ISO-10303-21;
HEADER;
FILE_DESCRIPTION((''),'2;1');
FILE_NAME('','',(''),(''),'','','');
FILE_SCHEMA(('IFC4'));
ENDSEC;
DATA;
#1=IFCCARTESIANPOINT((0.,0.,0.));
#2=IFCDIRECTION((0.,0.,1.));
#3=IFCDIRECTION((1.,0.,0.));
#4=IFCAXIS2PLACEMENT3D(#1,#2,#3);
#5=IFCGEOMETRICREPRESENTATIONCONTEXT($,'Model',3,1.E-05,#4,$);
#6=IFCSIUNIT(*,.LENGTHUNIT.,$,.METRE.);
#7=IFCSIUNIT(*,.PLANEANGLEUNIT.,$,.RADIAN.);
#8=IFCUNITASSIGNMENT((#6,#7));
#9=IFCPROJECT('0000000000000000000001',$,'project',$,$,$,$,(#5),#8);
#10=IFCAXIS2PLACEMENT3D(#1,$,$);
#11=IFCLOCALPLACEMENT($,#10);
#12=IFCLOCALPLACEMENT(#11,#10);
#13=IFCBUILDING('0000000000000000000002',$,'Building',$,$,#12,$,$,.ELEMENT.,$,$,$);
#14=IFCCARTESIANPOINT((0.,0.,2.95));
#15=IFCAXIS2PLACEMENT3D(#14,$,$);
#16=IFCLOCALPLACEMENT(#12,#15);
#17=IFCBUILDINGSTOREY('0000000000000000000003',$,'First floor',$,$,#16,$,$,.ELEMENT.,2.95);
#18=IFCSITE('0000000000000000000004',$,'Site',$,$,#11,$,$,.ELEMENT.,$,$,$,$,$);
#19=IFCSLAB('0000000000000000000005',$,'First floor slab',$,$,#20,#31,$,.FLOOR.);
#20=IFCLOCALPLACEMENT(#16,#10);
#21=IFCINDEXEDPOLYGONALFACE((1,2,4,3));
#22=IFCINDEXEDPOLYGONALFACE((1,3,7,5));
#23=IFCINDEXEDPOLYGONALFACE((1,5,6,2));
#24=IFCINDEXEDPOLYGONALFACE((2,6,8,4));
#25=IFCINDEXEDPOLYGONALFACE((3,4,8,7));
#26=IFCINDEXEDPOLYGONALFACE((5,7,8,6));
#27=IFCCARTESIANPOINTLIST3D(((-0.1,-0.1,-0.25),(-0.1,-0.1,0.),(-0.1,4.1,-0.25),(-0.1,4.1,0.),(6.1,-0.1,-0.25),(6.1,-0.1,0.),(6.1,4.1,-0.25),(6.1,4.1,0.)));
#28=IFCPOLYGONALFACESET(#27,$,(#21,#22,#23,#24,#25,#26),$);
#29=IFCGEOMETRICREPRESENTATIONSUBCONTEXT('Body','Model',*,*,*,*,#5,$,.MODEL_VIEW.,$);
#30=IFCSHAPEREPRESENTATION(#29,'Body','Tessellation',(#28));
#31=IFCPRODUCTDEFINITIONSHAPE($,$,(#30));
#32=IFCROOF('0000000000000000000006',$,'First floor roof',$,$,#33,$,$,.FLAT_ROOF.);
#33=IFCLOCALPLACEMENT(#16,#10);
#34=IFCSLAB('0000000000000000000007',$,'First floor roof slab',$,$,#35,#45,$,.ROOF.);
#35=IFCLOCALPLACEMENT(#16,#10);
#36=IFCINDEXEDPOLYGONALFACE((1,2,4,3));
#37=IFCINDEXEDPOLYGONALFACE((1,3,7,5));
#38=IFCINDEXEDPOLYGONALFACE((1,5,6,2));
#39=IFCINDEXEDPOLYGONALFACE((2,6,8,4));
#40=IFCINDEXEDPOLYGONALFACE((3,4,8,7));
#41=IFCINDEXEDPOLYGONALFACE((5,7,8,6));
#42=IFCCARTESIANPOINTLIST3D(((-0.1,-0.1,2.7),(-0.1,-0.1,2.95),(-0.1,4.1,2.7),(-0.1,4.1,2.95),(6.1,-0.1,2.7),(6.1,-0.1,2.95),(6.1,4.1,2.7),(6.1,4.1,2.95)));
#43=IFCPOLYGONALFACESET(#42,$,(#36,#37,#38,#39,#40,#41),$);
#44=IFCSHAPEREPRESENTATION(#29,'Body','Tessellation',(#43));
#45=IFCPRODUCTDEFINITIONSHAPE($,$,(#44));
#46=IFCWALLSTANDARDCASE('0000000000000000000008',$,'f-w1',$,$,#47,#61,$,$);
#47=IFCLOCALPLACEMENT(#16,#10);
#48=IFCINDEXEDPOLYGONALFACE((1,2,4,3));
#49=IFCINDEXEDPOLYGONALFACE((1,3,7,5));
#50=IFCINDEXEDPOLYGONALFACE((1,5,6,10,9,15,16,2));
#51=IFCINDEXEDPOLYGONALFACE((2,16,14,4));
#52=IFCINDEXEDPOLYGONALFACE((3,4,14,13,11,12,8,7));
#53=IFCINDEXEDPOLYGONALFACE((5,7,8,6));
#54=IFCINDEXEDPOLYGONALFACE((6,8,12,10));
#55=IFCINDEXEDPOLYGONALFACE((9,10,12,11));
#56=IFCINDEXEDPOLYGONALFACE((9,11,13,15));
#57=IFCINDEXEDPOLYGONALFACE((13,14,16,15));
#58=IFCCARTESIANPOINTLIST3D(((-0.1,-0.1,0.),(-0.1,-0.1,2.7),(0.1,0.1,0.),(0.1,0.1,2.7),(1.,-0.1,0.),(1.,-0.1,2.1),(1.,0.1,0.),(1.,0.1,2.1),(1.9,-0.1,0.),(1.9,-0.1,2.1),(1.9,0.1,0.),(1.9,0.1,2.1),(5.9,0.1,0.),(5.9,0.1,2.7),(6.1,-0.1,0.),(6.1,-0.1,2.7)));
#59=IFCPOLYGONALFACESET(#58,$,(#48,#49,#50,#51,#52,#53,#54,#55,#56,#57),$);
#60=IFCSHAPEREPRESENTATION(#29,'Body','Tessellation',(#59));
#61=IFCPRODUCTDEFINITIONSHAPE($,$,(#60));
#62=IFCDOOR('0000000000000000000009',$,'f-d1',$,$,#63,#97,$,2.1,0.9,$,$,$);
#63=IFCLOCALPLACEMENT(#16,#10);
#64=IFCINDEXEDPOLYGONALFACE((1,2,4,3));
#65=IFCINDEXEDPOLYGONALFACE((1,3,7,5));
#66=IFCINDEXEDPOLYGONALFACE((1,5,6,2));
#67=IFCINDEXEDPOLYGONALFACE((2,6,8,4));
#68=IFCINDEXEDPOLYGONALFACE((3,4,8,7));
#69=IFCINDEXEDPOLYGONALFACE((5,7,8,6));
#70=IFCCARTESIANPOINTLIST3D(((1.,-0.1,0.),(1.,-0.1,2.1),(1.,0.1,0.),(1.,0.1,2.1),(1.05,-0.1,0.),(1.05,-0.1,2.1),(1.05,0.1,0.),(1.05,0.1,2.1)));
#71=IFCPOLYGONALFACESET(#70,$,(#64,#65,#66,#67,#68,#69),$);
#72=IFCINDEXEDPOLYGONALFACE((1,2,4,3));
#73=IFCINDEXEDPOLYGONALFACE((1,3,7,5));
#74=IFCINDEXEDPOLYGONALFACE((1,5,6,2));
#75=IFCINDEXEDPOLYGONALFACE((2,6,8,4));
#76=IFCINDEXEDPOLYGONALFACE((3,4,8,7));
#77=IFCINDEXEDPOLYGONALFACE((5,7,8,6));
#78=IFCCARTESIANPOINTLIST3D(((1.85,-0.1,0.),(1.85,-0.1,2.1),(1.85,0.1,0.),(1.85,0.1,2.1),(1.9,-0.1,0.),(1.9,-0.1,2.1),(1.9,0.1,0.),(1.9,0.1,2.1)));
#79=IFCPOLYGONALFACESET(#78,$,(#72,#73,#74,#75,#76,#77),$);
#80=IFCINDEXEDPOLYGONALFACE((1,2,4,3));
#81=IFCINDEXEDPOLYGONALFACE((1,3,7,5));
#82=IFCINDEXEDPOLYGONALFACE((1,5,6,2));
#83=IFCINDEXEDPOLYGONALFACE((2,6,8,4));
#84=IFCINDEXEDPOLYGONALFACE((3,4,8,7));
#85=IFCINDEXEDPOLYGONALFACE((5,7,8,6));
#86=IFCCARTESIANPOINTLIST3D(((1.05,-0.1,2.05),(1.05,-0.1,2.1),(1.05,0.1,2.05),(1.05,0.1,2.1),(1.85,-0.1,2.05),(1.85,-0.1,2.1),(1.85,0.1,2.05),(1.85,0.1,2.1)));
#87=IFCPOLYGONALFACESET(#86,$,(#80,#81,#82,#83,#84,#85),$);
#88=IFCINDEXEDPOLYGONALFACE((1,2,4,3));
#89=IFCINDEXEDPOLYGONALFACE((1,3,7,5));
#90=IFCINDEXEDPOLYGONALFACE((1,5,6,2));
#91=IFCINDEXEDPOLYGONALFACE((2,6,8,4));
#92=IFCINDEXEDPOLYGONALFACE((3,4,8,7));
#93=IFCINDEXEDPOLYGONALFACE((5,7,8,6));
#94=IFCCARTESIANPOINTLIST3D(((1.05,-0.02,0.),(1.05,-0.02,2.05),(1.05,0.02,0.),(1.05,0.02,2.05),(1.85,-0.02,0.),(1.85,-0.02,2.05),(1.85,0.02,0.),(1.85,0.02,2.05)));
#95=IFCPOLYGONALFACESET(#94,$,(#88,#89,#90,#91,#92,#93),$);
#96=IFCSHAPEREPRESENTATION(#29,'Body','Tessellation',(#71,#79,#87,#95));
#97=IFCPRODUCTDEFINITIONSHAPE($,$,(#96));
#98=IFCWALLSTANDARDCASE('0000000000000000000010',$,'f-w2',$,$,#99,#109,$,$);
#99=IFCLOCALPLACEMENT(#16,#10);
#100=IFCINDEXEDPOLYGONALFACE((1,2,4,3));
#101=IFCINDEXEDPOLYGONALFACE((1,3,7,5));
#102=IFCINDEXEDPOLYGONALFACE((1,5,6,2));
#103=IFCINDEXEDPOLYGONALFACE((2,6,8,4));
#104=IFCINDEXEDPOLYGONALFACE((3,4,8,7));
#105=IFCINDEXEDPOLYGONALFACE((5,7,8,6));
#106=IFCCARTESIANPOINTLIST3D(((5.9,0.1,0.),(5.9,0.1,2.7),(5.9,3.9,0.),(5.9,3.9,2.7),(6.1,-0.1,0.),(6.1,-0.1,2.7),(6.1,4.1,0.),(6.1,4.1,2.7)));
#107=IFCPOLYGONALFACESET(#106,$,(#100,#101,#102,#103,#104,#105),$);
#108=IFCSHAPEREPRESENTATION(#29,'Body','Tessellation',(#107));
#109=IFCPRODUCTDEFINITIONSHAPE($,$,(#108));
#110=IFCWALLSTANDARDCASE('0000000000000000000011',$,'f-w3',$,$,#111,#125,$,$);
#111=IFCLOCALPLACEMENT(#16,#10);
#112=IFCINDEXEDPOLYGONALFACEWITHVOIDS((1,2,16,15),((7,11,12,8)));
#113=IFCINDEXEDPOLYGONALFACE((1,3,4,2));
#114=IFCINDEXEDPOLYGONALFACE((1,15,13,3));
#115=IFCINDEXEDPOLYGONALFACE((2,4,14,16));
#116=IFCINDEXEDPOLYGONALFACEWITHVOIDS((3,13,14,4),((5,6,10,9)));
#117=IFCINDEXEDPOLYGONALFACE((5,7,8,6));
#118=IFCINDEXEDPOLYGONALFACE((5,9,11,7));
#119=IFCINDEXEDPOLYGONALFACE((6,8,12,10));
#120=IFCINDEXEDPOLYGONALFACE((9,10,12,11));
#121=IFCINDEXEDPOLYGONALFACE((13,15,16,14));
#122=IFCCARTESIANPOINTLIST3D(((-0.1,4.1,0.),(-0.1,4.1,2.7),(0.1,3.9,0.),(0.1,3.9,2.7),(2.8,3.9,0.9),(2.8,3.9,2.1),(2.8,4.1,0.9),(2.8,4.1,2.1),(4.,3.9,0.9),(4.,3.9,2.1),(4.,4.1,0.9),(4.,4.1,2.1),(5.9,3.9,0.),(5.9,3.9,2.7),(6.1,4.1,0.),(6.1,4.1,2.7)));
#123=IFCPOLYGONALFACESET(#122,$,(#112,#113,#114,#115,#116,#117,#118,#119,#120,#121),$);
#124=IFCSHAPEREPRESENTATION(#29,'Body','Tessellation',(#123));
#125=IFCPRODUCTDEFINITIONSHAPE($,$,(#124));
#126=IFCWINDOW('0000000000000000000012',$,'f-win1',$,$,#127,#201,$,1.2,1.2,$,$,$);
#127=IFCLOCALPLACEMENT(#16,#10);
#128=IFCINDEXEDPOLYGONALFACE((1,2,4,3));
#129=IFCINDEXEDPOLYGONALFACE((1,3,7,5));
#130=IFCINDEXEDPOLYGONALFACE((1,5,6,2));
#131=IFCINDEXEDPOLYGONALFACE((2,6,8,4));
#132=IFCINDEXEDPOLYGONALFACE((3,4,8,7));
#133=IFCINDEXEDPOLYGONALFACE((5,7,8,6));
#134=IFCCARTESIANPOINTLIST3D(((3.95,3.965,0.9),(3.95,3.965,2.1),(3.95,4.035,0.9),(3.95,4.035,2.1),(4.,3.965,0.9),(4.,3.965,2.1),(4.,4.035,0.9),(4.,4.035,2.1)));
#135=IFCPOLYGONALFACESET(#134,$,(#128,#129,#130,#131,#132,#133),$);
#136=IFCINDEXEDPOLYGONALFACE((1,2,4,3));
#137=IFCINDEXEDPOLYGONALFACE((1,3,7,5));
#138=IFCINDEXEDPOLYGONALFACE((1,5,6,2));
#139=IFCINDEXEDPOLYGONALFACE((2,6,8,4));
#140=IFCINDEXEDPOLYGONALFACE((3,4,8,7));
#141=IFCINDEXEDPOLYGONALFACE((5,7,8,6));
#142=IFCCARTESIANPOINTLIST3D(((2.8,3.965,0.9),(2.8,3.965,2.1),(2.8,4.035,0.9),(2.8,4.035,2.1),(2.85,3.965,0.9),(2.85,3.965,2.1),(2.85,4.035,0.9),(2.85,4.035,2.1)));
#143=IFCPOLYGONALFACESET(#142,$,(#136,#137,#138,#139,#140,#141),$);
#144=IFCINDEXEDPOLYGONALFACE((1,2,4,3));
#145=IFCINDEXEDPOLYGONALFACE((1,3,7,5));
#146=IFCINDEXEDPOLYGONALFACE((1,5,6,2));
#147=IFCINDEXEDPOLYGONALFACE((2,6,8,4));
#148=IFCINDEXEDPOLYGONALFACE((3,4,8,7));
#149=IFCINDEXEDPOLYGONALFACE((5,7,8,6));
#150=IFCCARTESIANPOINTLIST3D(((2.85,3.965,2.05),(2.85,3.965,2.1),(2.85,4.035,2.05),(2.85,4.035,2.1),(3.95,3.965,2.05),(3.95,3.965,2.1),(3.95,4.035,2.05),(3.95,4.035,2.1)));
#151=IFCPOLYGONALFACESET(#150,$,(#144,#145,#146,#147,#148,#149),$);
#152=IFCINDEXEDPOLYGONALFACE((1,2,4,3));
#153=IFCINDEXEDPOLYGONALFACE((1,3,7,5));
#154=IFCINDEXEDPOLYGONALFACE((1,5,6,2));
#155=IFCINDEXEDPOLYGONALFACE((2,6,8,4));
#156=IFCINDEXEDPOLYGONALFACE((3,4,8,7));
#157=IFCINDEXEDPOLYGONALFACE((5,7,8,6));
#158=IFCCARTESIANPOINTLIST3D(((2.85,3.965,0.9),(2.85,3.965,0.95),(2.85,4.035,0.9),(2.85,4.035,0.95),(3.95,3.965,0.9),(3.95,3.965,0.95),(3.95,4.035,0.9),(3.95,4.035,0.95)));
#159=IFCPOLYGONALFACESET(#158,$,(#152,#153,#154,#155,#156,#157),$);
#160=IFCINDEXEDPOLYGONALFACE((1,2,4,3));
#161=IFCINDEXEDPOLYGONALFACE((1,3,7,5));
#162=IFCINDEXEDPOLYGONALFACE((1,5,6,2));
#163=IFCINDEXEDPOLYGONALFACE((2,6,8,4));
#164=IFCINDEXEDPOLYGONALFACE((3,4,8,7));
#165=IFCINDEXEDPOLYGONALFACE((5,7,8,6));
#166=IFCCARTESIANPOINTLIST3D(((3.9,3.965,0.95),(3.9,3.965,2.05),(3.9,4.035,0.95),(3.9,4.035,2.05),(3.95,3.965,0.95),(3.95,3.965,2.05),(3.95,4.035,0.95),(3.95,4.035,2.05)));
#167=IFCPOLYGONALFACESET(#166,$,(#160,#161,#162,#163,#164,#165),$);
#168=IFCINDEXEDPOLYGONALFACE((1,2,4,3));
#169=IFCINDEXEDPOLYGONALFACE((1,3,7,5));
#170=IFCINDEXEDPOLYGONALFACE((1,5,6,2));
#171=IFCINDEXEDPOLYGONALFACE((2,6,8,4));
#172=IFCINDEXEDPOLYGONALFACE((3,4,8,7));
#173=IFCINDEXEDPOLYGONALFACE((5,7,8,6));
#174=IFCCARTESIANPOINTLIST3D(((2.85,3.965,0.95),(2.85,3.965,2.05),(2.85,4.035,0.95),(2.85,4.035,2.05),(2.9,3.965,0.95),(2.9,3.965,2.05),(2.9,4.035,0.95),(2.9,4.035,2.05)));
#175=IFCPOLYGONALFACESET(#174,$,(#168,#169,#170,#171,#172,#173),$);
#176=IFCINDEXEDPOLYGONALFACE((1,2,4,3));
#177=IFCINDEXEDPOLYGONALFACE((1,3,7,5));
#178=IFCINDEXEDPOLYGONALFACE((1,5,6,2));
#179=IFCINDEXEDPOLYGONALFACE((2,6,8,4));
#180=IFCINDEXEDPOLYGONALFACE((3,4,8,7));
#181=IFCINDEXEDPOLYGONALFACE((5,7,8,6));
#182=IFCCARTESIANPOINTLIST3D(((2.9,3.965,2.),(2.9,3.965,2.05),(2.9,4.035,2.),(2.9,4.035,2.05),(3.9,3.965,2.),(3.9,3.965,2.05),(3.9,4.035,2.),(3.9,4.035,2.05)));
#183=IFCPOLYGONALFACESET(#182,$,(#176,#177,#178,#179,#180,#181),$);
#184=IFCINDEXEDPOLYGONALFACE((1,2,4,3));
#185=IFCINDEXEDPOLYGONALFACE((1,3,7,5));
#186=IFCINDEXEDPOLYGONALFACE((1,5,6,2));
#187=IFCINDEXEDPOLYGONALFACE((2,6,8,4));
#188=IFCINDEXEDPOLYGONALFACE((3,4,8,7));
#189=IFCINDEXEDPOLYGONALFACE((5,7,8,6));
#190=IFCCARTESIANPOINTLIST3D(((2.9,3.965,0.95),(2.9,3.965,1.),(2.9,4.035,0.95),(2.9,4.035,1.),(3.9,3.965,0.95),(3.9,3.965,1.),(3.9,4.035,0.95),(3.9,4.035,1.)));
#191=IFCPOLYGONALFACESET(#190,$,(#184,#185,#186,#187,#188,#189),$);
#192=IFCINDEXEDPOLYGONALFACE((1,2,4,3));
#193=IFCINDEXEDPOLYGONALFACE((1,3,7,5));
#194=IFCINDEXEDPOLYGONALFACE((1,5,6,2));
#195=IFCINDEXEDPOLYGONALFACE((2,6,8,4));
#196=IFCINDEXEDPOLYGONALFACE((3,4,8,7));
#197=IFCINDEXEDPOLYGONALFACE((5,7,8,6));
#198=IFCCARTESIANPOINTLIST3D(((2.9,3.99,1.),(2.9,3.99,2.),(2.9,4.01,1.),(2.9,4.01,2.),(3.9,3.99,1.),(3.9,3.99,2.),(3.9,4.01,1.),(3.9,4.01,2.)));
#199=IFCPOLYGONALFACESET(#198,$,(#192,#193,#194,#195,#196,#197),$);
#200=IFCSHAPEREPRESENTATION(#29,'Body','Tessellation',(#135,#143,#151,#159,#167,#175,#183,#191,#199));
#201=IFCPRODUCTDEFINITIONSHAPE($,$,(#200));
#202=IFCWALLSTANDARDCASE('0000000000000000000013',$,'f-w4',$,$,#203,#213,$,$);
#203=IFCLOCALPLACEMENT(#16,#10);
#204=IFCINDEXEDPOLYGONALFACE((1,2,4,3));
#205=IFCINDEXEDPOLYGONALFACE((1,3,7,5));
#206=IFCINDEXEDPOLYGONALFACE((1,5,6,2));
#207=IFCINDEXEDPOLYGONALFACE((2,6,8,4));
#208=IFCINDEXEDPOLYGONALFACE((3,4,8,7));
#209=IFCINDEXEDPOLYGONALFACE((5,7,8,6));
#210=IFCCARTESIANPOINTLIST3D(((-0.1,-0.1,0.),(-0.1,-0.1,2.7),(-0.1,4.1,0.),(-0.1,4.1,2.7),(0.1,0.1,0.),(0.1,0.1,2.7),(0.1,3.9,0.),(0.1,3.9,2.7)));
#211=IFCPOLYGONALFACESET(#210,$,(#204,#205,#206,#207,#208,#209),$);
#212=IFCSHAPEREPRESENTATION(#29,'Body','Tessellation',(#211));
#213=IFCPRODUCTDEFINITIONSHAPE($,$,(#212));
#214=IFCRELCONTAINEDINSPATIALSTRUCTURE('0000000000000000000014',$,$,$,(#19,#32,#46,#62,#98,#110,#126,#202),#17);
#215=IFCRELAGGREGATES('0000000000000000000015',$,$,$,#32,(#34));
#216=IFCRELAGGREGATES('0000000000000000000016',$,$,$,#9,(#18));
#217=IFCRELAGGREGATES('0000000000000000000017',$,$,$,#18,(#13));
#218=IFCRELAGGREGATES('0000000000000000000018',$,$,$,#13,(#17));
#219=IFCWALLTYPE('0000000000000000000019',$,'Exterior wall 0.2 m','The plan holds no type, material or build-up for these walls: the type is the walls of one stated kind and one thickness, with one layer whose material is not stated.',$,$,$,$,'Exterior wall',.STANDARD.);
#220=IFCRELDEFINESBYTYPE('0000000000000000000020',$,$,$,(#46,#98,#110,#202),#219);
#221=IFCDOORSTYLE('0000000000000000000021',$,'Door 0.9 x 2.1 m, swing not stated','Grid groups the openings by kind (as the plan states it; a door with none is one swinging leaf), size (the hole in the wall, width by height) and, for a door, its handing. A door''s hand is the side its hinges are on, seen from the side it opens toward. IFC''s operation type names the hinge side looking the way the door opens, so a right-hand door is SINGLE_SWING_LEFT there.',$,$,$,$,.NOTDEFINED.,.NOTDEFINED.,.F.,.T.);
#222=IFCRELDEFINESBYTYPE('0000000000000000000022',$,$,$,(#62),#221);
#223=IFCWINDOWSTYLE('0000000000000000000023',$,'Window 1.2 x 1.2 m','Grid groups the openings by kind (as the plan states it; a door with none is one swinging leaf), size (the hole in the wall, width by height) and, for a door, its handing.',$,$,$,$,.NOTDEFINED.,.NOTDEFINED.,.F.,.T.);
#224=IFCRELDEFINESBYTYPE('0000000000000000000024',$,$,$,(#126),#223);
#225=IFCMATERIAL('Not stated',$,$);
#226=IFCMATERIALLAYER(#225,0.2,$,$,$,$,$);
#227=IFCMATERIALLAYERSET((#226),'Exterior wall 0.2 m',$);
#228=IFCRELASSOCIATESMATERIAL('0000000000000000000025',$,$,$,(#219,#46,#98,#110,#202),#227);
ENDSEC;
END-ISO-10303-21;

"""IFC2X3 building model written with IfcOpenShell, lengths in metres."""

from ifc_helpers import new_model, si_unit, frame, frame_2d, origin, origin_with_axes, place, context, subcontext, project, spatial, polyline, rectangle, outline, extrude, material, layer, layer_set, layer_usage, type_object, element, fill, aggregate, save


model = new_model("IFC2X3")

# Units and contexts
model_context = context("Model", 3, precision=1e-05, world=origin_with_axes())
body_context = subcontext(model_context, "Body", "Model", "MODEL_VIEW")
ifc_project = project(units=[si_unit("LENGTHUNIT", "METRE"), si_unit("PLANEANGLEUNIT", "RADIAN")], contexts=[model_context])

# Site, building, storey
site_placement = place(None, origin())
site = spatial("IfcSite", under=ifc_project, at=site_placement, Name="Site", CompositionType="ELEMENT")
building_placement = place(site_placement, origin())
building = spatial("IfcBuilding", under=site, at=building_placement, Name="Building", CompositionType="ELEMENT")
storey_placement = place(building_placement, frame((0.0, 0.0, 2.95)))
storey = spatial("IfcBuildingStorey", under=building, at=storey_placement, Name="First floor", CompositionType="ELEMENT", Elevation=2.95)

# Slab
slab_1_placement = place(storey_placement, frame((0.0, 0.0, -0.25)))
element("IfcSlab", 1, at=slab_1_placement, inside=storey, Name="First floor slab", PredefinedType="FLOOR", context=body_context, shape_type="SweptSolid", body=[
    extrude(outline(polyline([(-0.1, -0.1), (6.1, -0.1), (6.1, 4.1), (-0.1, 4.1), (-0.1, -0.1)])), origin(), (0.0, 0.0, 1.0), 0.25),
])

# Roof, slab
roof_placement = place(storey_placement, origin())
roof = element("IfcRoof", 2, at=roof_placement, inside=storey, Name="First floor roof", ShapeType="FLAT_ROOF")
slab_2_placement = place(storey_placement, frame((0.0, 0.0, 2.7)))
slab_2 = element("IfcSlab", 3, at=slab_2_placement, Name="First floor roof slab", PredefinedType="ROOF", context=body_context, shape_type="SweptSolid", body=[
    extrude(outline(polyline([(-0.1, -0.1), (6.1, -0.1), (6.1, 4.1), (-0.1, 4.1), (-0.1, -0.1)])), origin(), (0.0, 0.0, 1.0), 0.25),
])
aggregate(roof, [slab_2])

# Wall, opening, door
ifc_material = material(Name="Not stated")
ifc_layer = layer(ifc_material, 0.2)
ifc_layer_set = layer_set([ifc_layer], Name="Exterior wall 0.2 m")
ifc_layer_usage = layer_usage(ifc_layer_set, "AXIS2", "POSITIVE", -0.1)
wall_type = type_object("IfcWallType", Name="Exterior wall 0.2 m", Description="The plan holds no type, material or build-up for these walls: the type is the walls of one stated kind and one thickness, with one layer whose material is not stated.", ElementType="Exterior wall", PredefinedType="STANDARD", material=ifc_layer_set)
wall_1_placement = place(storey_placement, origin_with_axes())
wall_1 = element("IfcWallStandardCase", 4, at=wall_1_placement, inside=storey, type_object=wall_type, material=ifc_layer_usage, Name="f-w1", context=body_context, shape_type="SweptSolid", body=[
    extrude(outline(polyline([(-0.1, -0.1), (6.1, -0.1), (5.9, 0.1), (0.1, 0.1), (-0.1, -0.1)])), origin(), (0.0, 0.0, 1.0), 2.7),
])
opening_1_placement = place(wall_1_placement, frame((1.0, 0.0, 0.0)))
opening_1 = element("IfcOpeningElement", 5, at=opening_1_placement, cuts=wall_1, context=body_context, shape_type="SweptSolid", body=[
    extrude(rectangle(XDim=0.9, YDim=0.22, at=frame_2d((0.45, 0.0), x_axis=(1.0, 0.0))), origin(), (0.0, 0.0, 1.0), 2.1),
])
door_style = type_object("IfcDoorStyle", Name="Door 0.9 x 2.1 m, swing not stated", Description="Grid groups the openings by kind (as the plan states it; a door with none is one swinging leaf), size (the hole in the wall, width by height) and, for a door, its handing. A door's hand is the side its hinges are on, seen from the side it opens toward. IFC's operation type names the hinge side looking the way the door opens, so a right-hand door is SINGLE_SWING_LEFT there.", ConstructionType="NOTDEFINED", OperationType="NOTDEFINED", ParameterTakesPrecedence=False, Sizeable=True)
door_placement = place(opening_1_placement, origin())
door = element("IfcDoor", 6, at=door_placement, inside=storey, type_object=door_style, Name="f-d1", OverallHeight=2.1, OverallWidth=0.9, context=body_context, shape_type="SweptSolid", body=[
    extrude(rectangle(XDim=0.05, YDim=0.2, at=frame_2d((0.025, 0.0), x_axis=(1.0, 0.0))), origin(), (0.0, 0.0, 1.0), 2.1),
    extrude(rectangle(XDim=0.05, YDim=0.2, at=frame_2d((0.875, 0.0), x_axis=(1.0, 0.0))), origin(), (0.0, 0.0, 1.0), 2.1),
    extrude(rectangle(XDim=0.8, YDim=0.2, at=frame_2d((0.45, 0.0), x_axis=(1.0, 0.0))), frame((0.0, 0.0, 2.05)), (0.0, 0.0, 1.0), 0.05),
    extrude(rectangle(XDim=0.8, YDim=0.04, at=frame_2d((0.45, 0.0), x_axis=(1.0, 0.0))), origin(), (0.0, 0.0, 1.0), 2.05),
])
fill(opening_1, door)

# Wall
wall_2_placement = place(storey_placement, frame((6.0, 0.0, 0.0), z_axis=(0.0, 0.0, 1.0), x_axis=(0.0, 1.0, 0.0)))
element("IfcWallStandardCase", 7, at=wall_2_placement, inside=storey, type_object=wall_type, material=ifc_layer_usage, Name="f-w2", context=body_context, shape_type="SweptSolid", body=[
    extrude(outline(polyline([(-0.1, -0.1), (4.1, -0.1), (3.9, 0.1), (0.1, 0.1), (-0.1, -0.1)])), origin(), (0.0, 0.0, 1.0), 2.7),
])

# Wall, opening, window
wall_3_placement = place(storey_placement, frame((6.0, 4.0, 0.0), z_axis=(0.0, 0.0, 1.0), x_axis=(-1.0, 0.0, 0.0)))
wall_3 = element("IfcWallStandardCase", 8, at=wall_3_placement, inside=storey, type_object=wall_type, material=ifc_layer_usage, Name="f-w3", context=body_context, shape_type="SweptSolid", body=[
    extrude(outline(polyline([(-0.1, -0.1), (6.1, -0.1), (5.9, 0.1), (0.1, 0.1), (-0.1, -0.1)])), origin(), (0.0, 0.0, 1.0), 2.7),
])
opening_2_placement = place(wall_3_placement, frame((2.0, 0.0, 0.9)))
opening_2 = element("IfcOpeningElement", 9, at=opening_2_placement, cuts=wall_3, context=body_context, shape_type="SweptSolid", body=[
    extrude(rectangle(XDim=1.2, YDim=0.22, at=frame_2d((0.6, 0.0), x_axis=(1.0, 0.0))), origin(), (0.0, 0.0, 1.0), 1.2),
])
window_style = type_object("IfcWindowStyle", Name="Window 1.2 x 1.2 m", Description="Grid groups the openings by kind (as the plan states it; a door with none is one swinging leaf), size (the hole in the wall, width by height) and, for a door, its handing.", ConstructionType="NOTDEFINED", OperationType="NOTDEFINED", ParameterTakesPrecedence=False, Sizeable=True)
window_placement = place(opening_2_placement, origin())
window = element("IfcWindow", 10, at=window_placement, inside=storey, type_object=window_style, Name="f-win1", OverallHeight=1.2, OverallWidth=1.2, context=body_context, shape_type="SweptSolid", body=[
    extrude(rectangle(XDim=0.05, YDim=0.07, at=frame_2d((0.025, 0.0), x_axis=(1.0, 0.0))), origin(), (0.0, 0.0, 1.0), 1.2),
    extrude(rectangle(XDim=0.05, YDim=0.07, at=frame_2d((1.175, 0.0), x_axis=(1.0, 0.0))), origin(), (0.0, 0.0, 1.0), 1.2),
    extrude(rectangle(XDim=1.1, YDim=0.07, at=frame_2d((0.6, 0.0), x_axis=(1.0, 0.0))), frame((0.0, 0.0, 1.15)), (0.0, 0.0, 1.0), 0.05),
    extrude(rectangle(XDim=1.1, YDim=0.07, at=frame_2d((0.6, 0.0), x_axis=(1.0, 0.0))), origin(), (0.0, 0.0, 1.0), 0.05),
    extrude(rectangle(XDim=0.05, YDim=0.07, at=frame_2d((0.075, 0.0), x_axis=(1.0, 0.0))), frame((0.0, 0.0, 0.05)), (0.0, 0.0, 1.0), 1.1),
    extrude(rectangle(XDim=0.05, YDim=0.07, at=frame_2d((1.125, 0.0), x_axis=(1.0, 0.0))), frame((0.0, 0.0, 0.05)), (0.0, 0.0, 1.0), 1.1),
    extrude(rectangle(XDim=1.0, YDim=0.07, at=frame_2d((0.6, 0.0), x_axis=(1.0, 0.0))), frame((0.0, 0.0, 1.1)), (0.0, 0.0, 1.0), 0.05),
    extrude(rectangle(XDim=1.0, YDim=0.07, at=frame_2d((0.6, 0.0), x_axis=(1.0, 0.0))), frame((0.0, 0.0, 0.05)), (0.0, 0.0, 1.0), 0.05),
    extrude(rectangle(XDim=1.0, YDim=0.02, at=frame_2d((0.6, 0.0), x_axis=(1.0, 0.0))), frame((0.0, 0.0, 0.1)), (0.0, 0.0, 1.0), 1.0),
])
fill(opening_2, window)

# Wall
wall_4_placement = place(storey_placement, frame((0.0, 4.0, 0.0), z_axis=(0.0, 0.0, 1.0), x_axis=(0.0, -1.0, 0.0)))
element("IfcWallStandardCase", 11, at=wall_4_placement, inside=storey, type_object=wall_type, material=ifc_layer_usage, Name="f-w4", context=body_context, shape_type="SweptSolid", body=[
    extrude(outline(polyline([(-0.1, -0.1), (4.1, -0.1), (3.9, 0.1), (0.1, 0.1), (-0.1, -0.1)])), origin(), (0.0, 0.0, 1.0), 2.7),
])

save(model, "model.ifc")
